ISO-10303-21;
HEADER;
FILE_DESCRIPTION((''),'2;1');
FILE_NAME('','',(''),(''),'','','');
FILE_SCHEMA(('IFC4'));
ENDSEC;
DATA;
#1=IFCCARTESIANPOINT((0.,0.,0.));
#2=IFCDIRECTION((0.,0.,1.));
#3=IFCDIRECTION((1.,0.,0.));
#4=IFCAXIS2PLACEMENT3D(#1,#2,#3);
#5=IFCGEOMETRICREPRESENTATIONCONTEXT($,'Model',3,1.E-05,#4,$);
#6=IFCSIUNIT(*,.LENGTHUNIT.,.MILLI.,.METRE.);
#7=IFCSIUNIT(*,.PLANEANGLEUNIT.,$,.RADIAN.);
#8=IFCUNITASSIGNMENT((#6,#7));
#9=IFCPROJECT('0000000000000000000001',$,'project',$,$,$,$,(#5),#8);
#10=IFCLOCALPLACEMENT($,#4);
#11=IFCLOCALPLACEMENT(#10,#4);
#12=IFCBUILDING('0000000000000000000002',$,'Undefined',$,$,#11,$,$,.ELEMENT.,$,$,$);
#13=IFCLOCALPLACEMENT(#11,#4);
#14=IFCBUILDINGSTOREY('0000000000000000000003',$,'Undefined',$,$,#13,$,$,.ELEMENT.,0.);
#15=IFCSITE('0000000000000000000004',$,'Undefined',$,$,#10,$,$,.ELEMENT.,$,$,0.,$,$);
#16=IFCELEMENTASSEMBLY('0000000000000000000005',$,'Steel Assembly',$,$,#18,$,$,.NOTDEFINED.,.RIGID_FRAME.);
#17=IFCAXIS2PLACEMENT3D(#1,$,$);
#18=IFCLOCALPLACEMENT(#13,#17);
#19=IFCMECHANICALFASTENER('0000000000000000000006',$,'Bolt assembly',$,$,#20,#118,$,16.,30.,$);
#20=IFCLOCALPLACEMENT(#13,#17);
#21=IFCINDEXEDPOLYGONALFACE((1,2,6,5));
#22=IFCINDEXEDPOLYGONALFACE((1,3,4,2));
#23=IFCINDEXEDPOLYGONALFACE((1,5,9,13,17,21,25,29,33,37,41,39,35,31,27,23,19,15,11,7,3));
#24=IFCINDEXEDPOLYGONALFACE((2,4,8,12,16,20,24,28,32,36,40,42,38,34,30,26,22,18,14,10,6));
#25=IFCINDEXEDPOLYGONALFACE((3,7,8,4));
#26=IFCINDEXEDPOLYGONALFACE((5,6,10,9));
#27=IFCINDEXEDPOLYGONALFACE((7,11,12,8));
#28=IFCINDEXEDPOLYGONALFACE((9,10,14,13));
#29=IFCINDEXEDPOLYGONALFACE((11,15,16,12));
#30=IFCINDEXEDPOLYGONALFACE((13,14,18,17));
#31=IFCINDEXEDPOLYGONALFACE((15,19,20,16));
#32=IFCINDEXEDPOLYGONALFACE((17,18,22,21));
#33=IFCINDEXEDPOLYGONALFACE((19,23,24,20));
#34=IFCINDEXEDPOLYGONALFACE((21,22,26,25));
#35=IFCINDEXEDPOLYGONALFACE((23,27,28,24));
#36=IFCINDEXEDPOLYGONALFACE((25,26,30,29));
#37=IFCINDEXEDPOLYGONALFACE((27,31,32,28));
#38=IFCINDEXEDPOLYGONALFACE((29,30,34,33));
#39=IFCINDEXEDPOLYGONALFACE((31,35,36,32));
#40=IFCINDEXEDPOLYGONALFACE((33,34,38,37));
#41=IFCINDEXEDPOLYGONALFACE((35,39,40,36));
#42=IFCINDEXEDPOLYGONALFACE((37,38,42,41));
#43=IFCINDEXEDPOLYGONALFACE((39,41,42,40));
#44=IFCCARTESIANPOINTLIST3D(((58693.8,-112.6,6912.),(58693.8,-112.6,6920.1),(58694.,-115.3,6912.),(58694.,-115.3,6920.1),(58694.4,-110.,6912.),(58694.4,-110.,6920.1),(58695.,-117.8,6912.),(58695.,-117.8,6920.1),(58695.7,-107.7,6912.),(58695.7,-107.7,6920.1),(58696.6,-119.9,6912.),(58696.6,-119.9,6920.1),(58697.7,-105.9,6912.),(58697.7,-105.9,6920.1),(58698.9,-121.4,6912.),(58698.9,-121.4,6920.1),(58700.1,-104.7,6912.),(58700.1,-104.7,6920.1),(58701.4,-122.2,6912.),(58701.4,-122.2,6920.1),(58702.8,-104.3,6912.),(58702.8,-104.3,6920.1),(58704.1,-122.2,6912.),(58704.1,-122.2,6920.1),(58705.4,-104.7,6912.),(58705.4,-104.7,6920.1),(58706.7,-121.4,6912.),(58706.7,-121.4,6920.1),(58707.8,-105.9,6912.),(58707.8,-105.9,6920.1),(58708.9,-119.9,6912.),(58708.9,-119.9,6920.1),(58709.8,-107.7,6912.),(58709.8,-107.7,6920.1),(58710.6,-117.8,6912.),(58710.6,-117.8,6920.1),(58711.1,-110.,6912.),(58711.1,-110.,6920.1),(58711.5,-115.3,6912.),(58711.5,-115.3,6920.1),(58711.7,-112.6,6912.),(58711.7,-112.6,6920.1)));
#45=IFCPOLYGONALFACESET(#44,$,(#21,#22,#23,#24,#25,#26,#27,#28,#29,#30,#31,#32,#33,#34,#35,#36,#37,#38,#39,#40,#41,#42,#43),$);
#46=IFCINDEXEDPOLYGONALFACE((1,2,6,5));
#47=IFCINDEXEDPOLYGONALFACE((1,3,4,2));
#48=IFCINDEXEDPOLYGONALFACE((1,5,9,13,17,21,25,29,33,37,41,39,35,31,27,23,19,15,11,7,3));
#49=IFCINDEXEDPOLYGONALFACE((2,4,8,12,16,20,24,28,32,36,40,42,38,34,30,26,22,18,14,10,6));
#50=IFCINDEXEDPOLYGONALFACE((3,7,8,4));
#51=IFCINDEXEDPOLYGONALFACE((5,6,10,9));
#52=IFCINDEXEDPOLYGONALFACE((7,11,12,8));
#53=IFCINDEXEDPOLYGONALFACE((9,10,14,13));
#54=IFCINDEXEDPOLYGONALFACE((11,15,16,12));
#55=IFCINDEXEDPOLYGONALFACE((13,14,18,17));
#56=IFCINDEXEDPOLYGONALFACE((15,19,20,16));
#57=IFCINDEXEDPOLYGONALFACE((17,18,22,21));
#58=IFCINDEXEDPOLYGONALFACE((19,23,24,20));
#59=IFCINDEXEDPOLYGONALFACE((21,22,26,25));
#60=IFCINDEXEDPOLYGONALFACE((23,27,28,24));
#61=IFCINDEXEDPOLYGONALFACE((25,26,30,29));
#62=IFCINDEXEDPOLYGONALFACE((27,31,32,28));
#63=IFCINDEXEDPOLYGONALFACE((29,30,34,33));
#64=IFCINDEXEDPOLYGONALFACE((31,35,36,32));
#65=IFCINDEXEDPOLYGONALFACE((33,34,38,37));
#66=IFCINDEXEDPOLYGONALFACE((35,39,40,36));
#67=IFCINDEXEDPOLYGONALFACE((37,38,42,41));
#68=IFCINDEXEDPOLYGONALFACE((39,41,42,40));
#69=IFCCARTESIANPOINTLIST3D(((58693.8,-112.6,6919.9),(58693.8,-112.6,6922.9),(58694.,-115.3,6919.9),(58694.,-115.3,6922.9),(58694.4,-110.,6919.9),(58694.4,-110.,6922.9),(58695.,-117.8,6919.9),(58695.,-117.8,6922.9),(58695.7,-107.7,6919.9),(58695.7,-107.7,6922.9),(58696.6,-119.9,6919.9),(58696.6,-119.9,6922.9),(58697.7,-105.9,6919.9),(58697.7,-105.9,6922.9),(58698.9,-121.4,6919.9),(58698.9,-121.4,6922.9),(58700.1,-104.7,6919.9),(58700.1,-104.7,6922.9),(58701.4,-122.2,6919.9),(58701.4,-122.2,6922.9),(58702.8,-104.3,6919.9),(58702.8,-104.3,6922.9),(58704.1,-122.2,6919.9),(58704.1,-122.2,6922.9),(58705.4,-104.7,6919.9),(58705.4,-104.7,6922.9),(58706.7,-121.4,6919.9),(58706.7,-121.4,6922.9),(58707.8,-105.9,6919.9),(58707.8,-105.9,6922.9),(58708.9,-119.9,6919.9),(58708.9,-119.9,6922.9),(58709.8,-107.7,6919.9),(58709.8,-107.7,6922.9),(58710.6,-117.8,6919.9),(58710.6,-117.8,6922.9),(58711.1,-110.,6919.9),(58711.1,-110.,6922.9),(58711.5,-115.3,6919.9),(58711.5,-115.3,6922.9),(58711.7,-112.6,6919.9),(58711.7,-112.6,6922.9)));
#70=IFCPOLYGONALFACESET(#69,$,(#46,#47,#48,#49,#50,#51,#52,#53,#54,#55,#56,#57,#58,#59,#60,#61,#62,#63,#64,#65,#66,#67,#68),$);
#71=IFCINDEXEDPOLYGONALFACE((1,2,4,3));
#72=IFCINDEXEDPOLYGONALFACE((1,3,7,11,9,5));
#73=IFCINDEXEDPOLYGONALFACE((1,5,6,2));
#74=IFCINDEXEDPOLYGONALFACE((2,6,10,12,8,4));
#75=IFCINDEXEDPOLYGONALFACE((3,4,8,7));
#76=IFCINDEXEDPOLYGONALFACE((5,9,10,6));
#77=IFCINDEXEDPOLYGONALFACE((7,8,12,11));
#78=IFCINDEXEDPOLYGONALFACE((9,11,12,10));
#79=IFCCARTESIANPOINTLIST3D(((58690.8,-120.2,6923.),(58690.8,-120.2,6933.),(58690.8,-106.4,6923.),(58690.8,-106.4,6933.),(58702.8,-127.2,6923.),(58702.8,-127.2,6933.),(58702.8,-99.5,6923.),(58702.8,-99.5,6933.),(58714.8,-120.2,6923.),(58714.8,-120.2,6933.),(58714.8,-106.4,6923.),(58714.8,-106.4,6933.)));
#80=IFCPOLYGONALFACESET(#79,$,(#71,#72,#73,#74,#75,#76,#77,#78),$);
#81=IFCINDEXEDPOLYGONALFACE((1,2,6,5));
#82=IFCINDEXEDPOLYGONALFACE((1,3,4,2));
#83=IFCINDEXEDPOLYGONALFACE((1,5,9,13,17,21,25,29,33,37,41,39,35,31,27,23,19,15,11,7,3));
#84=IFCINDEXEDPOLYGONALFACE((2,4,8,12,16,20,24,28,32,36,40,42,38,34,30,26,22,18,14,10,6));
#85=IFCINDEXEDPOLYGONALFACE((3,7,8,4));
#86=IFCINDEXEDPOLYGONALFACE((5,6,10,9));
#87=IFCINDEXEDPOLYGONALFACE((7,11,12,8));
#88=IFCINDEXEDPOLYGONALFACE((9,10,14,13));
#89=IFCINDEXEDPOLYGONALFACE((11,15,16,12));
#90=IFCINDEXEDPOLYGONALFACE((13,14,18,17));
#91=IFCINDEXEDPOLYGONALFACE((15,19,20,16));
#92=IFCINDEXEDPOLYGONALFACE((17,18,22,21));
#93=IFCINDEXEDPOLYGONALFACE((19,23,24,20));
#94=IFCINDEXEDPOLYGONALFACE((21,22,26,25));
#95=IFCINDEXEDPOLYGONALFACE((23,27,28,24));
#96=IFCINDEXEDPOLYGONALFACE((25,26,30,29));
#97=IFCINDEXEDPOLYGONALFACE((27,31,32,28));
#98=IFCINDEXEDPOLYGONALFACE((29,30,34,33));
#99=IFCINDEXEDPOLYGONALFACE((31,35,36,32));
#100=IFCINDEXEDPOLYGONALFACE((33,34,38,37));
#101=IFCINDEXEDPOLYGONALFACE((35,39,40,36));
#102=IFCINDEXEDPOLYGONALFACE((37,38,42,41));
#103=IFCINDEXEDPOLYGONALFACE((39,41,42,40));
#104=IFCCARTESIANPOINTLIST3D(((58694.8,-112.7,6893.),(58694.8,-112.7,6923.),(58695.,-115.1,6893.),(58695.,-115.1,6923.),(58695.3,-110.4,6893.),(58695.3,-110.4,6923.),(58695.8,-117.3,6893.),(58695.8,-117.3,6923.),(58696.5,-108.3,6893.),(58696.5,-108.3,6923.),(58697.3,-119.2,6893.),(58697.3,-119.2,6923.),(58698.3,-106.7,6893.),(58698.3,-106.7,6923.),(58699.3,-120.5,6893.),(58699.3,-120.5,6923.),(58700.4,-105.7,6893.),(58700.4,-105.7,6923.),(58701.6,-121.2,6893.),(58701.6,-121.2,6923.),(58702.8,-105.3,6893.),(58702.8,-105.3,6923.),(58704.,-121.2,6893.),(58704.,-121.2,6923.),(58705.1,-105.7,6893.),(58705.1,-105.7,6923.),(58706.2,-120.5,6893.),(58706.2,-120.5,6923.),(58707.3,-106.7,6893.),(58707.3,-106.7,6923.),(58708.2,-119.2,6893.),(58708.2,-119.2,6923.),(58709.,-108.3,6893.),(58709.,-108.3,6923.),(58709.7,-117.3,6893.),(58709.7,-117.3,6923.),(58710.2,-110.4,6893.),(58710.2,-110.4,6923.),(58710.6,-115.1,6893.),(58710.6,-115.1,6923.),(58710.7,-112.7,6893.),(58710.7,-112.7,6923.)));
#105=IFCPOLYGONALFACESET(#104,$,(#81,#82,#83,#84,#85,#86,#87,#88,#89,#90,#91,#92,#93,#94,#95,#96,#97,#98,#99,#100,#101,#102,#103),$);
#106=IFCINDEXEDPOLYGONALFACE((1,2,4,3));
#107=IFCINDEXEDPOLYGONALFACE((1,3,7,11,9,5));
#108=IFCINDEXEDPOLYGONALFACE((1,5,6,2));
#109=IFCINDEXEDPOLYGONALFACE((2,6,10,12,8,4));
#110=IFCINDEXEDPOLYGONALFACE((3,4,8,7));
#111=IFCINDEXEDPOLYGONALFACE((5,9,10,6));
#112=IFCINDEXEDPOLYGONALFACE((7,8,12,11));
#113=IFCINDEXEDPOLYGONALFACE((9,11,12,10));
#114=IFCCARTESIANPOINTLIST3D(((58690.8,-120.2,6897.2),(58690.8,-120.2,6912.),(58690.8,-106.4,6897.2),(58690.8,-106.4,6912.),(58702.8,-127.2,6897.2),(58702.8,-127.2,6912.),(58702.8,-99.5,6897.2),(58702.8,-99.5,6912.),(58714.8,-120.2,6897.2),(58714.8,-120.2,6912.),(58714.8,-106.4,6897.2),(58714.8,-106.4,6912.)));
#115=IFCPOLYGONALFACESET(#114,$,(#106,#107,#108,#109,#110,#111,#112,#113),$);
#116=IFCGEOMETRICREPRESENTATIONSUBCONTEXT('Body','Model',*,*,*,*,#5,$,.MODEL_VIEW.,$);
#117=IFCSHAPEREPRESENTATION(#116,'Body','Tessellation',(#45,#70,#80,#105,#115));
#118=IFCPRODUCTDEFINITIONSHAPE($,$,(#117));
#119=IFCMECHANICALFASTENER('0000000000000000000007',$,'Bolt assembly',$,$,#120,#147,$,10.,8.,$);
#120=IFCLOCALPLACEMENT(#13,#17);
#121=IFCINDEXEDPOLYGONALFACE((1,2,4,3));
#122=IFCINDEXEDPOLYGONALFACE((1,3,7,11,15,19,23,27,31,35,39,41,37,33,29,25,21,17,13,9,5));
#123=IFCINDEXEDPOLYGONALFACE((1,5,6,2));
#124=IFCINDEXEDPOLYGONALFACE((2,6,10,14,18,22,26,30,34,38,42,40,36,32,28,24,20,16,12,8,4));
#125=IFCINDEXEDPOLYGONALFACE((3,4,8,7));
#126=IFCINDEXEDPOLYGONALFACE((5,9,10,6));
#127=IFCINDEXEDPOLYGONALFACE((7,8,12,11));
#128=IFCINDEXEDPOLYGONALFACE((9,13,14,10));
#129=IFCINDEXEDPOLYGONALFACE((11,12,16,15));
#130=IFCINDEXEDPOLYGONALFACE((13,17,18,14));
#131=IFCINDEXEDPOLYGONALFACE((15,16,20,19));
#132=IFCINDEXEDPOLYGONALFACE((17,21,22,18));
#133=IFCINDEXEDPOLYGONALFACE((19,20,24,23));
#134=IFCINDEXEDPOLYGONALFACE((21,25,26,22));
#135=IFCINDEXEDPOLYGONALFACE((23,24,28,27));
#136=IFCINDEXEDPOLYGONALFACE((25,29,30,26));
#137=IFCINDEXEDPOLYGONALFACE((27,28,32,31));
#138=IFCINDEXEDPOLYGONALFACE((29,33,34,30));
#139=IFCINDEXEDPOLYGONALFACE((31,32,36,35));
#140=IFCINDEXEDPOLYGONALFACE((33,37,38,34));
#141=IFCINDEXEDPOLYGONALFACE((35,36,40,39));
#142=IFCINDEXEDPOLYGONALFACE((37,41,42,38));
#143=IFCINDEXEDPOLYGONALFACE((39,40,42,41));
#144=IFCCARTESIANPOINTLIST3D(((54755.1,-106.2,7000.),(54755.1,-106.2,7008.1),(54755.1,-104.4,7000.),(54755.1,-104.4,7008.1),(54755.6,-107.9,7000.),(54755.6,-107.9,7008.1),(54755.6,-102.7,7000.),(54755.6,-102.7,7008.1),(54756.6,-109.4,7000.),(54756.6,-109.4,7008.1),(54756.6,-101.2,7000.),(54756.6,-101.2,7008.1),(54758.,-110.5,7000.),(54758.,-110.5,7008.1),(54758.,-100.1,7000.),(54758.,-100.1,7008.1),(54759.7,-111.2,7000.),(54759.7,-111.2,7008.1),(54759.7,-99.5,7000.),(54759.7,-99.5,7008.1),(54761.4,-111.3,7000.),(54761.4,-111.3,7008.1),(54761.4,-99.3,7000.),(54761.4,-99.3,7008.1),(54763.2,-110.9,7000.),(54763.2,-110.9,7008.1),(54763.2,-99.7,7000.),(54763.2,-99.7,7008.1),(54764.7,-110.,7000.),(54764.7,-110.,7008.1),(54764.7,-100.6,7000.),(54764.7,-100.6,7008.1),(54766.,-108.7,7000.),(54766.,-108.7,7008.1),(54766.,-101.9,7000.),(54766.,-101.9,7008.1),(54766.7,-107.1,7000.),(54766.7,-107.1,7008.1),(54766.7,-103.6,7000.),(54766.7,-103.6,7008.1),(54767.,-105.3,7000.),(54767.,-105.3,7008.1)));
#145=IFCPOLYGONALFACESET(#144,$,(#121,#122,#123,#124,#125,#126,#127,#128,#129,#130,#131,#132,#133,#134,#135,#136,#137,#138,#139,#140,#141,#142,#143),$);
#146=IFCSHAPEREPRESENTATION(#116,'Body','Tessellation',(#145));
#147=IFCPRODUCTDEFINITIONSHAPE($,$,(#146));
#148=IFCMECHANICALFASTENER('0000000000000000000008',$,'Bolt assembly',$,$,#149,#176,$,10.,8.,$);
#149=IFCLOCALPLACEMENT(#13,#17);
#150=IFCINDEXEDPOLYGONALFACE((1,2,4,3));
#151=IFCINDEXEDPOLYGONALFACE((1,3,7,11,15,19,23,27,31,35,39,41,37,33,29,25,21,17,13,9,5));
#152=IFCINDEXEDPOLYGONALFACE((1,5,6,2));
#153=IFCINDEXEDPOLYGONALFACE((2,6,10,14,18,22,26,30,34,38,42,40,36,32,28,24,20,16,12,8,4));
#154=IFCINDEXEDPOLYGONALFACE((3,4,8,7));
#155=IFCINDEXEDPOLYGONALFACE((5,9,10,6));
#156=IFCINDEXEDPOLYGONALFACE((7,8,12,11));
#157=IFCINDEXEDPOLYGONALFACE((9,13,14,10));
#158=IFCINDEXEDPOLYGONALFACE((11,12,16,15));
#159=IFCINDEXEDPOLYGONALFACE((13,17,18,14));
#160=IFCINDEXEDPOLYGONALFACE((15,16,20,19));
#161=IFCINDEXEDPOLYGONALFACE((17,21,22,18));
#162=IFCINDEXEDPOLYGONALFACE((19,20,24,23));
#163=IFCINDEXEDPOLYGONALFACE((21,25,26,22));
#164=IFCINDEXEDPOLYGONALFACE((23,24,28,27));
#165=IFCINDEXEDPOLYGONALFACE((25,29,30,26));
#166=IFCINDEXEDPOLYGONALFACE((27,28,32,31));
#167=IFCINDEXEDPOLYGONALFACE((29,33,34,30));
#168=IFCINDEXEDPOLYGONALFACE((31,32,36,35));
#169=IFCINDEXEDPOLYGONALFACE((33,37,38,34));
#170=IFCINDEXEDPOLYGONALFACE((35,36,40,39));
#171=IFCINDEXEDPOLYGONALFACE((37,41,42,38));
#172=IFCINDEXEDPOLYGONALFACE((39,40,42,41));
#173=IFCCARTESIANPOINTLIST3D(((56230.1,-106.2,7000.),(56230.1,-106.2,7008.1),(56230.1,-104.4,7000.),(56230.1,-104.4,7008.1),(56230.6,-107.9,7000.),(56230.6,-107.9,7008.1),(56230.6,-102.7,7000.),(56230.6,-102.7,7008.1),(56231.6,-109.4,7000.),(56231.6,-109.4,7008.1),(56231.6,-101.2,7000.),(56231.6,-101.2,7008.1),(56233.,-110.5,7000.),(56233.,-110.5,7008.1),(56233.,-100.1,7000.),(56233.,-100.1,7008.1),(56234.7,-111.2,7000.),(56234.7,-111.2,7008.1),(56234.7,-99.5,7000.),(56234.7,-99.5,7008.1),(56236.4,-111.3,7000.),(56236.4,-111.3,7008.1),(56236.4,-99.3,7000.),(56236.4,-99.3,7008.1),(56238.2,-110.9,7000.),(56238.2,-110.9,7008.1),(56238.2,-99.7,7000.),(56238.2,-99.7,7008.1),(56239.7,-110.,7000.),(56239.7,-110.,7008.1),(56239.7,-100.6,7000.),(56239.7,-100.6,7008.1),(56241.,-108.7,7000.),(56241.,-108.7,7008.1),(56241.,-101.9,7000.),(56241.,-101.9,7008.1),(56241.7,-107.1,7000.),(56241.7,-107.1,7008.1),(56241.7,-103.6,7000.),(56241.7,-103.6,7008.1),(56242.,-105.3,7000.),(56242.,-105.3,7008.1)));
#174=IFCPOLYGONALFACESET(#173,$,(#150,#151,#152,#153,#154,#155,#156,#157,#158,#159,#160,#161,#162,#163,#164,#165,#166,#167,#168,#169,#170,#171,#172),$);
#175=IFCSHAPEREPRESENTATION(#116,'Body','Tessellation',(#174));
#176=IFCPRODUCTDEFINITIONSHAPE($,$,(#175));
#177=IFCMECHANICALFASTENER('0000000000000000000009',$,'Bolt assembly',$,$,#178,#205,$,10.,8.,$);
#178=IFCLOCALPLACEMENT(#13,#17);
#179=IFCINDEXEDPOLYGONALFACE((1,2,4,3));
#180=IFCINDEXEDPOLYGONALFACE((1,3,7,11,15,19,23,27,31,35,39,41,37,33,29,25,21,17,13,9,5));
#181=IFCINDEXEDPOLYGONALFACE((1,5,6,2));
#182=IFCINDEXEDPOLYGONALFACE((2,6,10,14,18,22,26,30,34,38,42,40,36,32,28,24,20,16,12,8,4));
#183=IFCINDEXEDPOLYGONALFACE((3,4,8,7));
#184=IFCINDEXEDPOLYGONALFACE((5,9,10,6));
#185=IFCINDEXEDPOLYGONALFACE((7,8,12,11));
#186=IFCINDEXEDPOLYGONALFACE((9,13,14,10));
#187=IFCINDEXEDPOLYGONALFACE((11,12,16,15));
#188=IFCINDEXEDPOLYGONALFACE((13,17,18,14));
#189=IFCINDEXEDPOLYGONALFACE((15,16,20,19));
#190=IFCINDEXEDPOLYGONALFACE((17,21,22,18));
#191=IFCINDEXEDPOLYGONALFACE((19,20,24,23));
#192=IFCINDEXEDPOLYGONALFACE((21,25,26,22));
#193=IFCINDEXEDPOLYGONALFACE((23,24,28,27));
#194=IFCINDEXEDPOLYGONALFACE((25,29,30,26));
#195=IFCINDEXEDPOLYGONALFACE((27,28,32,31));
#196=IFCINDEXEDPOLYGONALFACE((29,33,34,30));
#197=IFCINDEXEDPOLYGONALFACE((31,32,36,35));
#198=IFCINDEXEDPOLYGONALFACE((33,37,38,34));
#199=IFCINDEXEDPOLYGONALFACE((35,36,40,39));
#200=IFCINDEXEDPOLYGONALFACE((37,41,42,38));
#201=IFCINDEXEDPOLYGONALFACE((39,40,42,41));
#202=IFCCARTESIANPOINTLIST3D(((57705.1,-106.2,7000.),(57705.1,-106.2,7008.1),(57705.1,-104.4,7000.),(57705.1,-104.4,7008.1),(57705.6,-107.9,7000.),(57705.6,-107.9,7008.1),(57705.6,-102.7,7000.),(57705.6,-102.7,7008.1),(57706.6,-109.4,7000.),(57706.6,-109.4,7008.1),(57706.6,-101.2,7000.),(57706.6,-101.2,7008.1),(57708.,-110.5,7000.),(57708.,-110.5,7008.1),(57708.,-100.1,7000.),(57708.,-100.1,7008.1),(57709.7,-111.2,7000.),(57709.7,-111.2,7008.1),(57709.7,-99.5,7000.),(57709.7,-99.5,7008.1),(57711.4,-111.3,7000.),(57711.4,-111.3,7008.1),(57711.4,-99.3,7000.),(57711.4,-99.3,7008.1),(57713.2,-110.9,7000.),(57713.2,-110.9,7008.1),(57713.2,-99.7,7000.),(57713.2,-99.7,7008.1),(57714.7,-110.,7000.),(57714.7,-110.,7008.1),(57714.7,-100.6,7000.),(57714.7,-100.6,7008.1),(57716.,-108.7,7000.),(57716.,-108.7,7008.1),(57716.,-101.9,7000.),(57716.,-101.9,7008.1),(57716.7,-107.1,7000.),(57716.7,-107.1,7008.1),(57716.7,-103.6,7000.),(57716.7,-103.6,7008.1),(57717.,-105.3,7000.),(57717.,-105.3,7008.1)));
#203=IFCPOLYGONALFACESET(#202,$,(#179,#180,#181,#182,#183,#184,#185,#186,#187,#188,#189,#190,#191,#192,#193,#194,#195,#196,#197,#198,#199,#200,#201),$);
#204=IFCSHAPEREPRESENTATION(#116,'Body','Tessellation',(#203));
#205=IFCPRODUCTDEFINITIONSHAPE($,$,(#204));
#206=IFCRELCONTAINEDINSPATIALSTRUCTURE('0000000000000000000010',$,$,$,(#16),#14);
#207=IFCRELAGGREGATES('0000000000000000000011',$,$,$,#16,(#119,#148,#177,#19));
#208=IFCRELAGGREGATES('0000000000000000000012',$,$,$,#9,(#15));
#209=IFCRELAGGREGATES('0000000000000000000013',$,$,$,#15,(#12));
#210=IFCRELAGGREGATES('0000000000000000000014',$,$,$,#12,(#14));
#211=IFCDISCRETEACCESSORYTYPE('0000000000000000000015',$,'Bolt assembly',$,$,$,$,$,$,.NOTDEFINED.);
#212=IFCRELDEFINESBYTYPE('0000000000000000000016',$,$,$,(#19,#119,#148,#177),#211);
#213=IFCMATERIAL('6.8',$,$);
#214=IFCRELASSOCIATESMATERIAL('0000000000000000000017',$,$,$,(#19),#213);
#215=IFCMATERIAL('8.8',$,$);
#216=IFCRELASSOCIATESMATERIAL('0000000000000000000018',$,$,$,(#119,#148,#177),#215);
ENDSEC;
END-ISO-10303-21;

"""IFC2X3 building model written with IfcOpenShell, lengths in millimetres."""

from ifc_helpers import new_model, si_unit, frame, origin_with_axes, origin_2d_with_axis, place, context, subcontext, project, spatial, polyline, circle, outline, extrude, source, transform, mapped, material, type_object, element, aggregate, save


model = new_model("IFC2X3")

# Units and contexts
model_context = context("Model", 3, precision=1e-05, world=origin_with_axes())
body_context = subcontext(model_context, "Body", "Model", "MODEL_VIEW")
ifc_project = project(units=[si_unit("LENGTHUNIT", "METRE", prefix="MILLI"), si_unit("PLANEANGLEUNIT", "RADIAN")], contexts=[model_context])

# Site, building, storey
site_placement = place(None, origin_with_axes())
site = spatial("IfcSite", under=ifc_project, at=site_placement, Name="Undefined", CompositionType="ELEMENT", RefElevation=0.0)
building_placement = place(site_placement, origin_with_axes())
building = spatial("IfcBuilding", under=site, at=building_placement, Name="Undefined", CompositionType="ELEMENT")
storey_placement = place(building_placement, origin_with_axes())
storey = spatial("IfcBuildingStorey", under=building, at=storey_placement, Name="Undefined", CompositionType="ELEMENT", Elevation=0.0)

# Element assembly
assembly_1_placement = place(storey_placement, origin_with_axes())
assembly_1 = element("IfcElementAssembly", 1, at=assembly_1_placement, inside=storey, Name="Steel Assembly", AssemblyPlace="NOTDEFINED", PredefinedType="RIGID_FRAME")

# Shared definitions
ifc_material_1 = material(Name="6.8")
discrete_accessory_type_1 = type_object("IfcDiscreteAccessoryType", Name="Bolt assembly")

# Shared definitions
ifc_material_2 = material(Name="8.8")

# Mechanical fasteners
shared_shape_1 = source(origin_with_axes(), body_context, "Body", "SweptSolid", [
    extrude(circle(Radius=9.0, at=origin_2d_with_axis()), frame((0.0, -0.1, 0.0), z_axis=(0.0, 1.0, 0.0), x_axis=(1.0, 0.0, 0.0)), (0.0, 0.0, 1.0), 8.1),
    extrude(circle(Radius=9.0, at=origin_2d_with_axis()), frame((0.0, -2.9, 0.0), z_axis=(0.0, 1.0, 0.0), x_axis=(1.0, 0.0, 0.0)), (0.0, 0.0, 1.0), 3.0),
    extrude(outline(polyline([(13.9, 0.0), (6.9, 12.0), (-6.9, 12.0), (-13.9, 0.0), (-6.9, -12.0), (6.9, -12.0), (13.9, 0.0)])), frame((0.0, -13.0, 0.0), z_axis=(0.0, 1.0, 0.0), x_axis=(1.0, 0.0, 0.0)), (0.0, 0.0, 1.0), 10.0),
    extrude(circle(Radius=8.0, at=origin_2d_with_axis()), frame((0.0, -3.0, 0.0), z_axis=(0.0, 1.0, 0.0), x_axis=(1.0, 0.0, 0.0)), (0.0, 0.0, 1.0), 30.0),
    extrude(outline(polyline([(13.9, 0.0), (6.9, 12.0), (-6.9, 12.0), (-13.9, 0.0), (-6.9, -12.0), (6.9, -12.0), (13.9, 0.0)])), frame((0.0, 8.0, 0.0), z_axis=(0.0, 1.0, 0.0), x_axis=(1.0, 0.0, 0.0)), (0.0, 0.0, 1.0), 14.8),
])
mechanical_fastener_1_placement = place(assembly_1_placement, frame((58702.8, -113.3, 6920.0), z_axis=(-1.0, 0.0, 0.0), x_axis=(0.0, 1.0, 0.0)))
mechanical_fastener_1 = element("IfcMechanicalFastener", 2, at=mechanical_fastener_1_placement, type_object=discrete_accessory_type_1, material=ifc_material_1, Name="Bolt assembly", NominalDiameter=16.0, NominalLength=30.0, context=body_context, shape_type="MappedRepresentation", body=[
    mapped(shared_shape_1, transform((0.0, 0.0, 0.0))),
])
shared_shape_2 = source(origin_with_axes(), body_context, "Body", "SweptSolid", [
    extrude(circle(Radius=6.0, at=origin_2d_with_axis()), frame((0.0, 0.0, 0.0), z_axis=(0.0, 1.0, 0.0), x_axis=(1.0, 0.0, 0.0)), (0.0, 0.0, 1.0), 8.1),
])
mechanical_fastener_2_placement = place(assembly_1_placement, frame((54761.0, -105.3, 7000.0), z_axis=(0.0, -1.0, 0.0), x_axis=(1.0, 0.0, 0.0)))
mechanical_fastener_2 = element("IfcMechanicalFastener", 3, at=mechanical_fastener_2_placement, type_object=discrete_accessory_type_1, material=ifc_material_2, Name="Bolt assembly", NominalDiameter=10.0, NominalLength=8.0, context=body_context, shape_type="MappedRepresentation", body=[
    mapped(shared_shape_2, transform((0.0, 0.0, 0.0))),
])
mechanical_fastener_3_placement = place(assembly_1_placement, frame((56236.0, -105.3, 7000.0), z_axis=(0.0, -1.0, 0.0), x_axis=(1.0, 0.0, 0.0)))
mechanical_fastener_3 = element("IfcMechanicalFastener", 4, at=mechanical_fastener_3_placement, type_object=discrete_accessory_type_1, material=ifc_material_2, Name="Bolt assembly", NominalDiameter=10.0, NominalLength=8.0, context=body_context, shape_type="MappedRepresentation", body=[
    mapped(shared_shape_2, transform((0.0, 0.0, 0.0))),
])
mechanical_fastener_4_placement = place(assembly_1_placement, frame((57711.0, -105.3, 7000.0), z_axis=(0.0, -1.0, 0.0), x_axis=(1.0, 0.0, 0.0)))
mechanical_fastener_4 = element("IfcMechanicalFastener", 5, at=mechanical_fastener_4_placement, type_object=discrete_accessory_type_1, material=ifc_material_2, Name="Bolt assembly", NominalDiameter=10.0, NominalLength=8.0, context=body_context, shape_type="MappedRepresentation", body=[
    mapped(shared_shape_2, transform((0.0, 0.0, 0.0))),
])

aggregate(assembly_1, [mechanical_fastener_2, mechanical_fastener_3, mechanical_fastener_4, mechanical_fastener_1])

save(model, "model.ifc")
